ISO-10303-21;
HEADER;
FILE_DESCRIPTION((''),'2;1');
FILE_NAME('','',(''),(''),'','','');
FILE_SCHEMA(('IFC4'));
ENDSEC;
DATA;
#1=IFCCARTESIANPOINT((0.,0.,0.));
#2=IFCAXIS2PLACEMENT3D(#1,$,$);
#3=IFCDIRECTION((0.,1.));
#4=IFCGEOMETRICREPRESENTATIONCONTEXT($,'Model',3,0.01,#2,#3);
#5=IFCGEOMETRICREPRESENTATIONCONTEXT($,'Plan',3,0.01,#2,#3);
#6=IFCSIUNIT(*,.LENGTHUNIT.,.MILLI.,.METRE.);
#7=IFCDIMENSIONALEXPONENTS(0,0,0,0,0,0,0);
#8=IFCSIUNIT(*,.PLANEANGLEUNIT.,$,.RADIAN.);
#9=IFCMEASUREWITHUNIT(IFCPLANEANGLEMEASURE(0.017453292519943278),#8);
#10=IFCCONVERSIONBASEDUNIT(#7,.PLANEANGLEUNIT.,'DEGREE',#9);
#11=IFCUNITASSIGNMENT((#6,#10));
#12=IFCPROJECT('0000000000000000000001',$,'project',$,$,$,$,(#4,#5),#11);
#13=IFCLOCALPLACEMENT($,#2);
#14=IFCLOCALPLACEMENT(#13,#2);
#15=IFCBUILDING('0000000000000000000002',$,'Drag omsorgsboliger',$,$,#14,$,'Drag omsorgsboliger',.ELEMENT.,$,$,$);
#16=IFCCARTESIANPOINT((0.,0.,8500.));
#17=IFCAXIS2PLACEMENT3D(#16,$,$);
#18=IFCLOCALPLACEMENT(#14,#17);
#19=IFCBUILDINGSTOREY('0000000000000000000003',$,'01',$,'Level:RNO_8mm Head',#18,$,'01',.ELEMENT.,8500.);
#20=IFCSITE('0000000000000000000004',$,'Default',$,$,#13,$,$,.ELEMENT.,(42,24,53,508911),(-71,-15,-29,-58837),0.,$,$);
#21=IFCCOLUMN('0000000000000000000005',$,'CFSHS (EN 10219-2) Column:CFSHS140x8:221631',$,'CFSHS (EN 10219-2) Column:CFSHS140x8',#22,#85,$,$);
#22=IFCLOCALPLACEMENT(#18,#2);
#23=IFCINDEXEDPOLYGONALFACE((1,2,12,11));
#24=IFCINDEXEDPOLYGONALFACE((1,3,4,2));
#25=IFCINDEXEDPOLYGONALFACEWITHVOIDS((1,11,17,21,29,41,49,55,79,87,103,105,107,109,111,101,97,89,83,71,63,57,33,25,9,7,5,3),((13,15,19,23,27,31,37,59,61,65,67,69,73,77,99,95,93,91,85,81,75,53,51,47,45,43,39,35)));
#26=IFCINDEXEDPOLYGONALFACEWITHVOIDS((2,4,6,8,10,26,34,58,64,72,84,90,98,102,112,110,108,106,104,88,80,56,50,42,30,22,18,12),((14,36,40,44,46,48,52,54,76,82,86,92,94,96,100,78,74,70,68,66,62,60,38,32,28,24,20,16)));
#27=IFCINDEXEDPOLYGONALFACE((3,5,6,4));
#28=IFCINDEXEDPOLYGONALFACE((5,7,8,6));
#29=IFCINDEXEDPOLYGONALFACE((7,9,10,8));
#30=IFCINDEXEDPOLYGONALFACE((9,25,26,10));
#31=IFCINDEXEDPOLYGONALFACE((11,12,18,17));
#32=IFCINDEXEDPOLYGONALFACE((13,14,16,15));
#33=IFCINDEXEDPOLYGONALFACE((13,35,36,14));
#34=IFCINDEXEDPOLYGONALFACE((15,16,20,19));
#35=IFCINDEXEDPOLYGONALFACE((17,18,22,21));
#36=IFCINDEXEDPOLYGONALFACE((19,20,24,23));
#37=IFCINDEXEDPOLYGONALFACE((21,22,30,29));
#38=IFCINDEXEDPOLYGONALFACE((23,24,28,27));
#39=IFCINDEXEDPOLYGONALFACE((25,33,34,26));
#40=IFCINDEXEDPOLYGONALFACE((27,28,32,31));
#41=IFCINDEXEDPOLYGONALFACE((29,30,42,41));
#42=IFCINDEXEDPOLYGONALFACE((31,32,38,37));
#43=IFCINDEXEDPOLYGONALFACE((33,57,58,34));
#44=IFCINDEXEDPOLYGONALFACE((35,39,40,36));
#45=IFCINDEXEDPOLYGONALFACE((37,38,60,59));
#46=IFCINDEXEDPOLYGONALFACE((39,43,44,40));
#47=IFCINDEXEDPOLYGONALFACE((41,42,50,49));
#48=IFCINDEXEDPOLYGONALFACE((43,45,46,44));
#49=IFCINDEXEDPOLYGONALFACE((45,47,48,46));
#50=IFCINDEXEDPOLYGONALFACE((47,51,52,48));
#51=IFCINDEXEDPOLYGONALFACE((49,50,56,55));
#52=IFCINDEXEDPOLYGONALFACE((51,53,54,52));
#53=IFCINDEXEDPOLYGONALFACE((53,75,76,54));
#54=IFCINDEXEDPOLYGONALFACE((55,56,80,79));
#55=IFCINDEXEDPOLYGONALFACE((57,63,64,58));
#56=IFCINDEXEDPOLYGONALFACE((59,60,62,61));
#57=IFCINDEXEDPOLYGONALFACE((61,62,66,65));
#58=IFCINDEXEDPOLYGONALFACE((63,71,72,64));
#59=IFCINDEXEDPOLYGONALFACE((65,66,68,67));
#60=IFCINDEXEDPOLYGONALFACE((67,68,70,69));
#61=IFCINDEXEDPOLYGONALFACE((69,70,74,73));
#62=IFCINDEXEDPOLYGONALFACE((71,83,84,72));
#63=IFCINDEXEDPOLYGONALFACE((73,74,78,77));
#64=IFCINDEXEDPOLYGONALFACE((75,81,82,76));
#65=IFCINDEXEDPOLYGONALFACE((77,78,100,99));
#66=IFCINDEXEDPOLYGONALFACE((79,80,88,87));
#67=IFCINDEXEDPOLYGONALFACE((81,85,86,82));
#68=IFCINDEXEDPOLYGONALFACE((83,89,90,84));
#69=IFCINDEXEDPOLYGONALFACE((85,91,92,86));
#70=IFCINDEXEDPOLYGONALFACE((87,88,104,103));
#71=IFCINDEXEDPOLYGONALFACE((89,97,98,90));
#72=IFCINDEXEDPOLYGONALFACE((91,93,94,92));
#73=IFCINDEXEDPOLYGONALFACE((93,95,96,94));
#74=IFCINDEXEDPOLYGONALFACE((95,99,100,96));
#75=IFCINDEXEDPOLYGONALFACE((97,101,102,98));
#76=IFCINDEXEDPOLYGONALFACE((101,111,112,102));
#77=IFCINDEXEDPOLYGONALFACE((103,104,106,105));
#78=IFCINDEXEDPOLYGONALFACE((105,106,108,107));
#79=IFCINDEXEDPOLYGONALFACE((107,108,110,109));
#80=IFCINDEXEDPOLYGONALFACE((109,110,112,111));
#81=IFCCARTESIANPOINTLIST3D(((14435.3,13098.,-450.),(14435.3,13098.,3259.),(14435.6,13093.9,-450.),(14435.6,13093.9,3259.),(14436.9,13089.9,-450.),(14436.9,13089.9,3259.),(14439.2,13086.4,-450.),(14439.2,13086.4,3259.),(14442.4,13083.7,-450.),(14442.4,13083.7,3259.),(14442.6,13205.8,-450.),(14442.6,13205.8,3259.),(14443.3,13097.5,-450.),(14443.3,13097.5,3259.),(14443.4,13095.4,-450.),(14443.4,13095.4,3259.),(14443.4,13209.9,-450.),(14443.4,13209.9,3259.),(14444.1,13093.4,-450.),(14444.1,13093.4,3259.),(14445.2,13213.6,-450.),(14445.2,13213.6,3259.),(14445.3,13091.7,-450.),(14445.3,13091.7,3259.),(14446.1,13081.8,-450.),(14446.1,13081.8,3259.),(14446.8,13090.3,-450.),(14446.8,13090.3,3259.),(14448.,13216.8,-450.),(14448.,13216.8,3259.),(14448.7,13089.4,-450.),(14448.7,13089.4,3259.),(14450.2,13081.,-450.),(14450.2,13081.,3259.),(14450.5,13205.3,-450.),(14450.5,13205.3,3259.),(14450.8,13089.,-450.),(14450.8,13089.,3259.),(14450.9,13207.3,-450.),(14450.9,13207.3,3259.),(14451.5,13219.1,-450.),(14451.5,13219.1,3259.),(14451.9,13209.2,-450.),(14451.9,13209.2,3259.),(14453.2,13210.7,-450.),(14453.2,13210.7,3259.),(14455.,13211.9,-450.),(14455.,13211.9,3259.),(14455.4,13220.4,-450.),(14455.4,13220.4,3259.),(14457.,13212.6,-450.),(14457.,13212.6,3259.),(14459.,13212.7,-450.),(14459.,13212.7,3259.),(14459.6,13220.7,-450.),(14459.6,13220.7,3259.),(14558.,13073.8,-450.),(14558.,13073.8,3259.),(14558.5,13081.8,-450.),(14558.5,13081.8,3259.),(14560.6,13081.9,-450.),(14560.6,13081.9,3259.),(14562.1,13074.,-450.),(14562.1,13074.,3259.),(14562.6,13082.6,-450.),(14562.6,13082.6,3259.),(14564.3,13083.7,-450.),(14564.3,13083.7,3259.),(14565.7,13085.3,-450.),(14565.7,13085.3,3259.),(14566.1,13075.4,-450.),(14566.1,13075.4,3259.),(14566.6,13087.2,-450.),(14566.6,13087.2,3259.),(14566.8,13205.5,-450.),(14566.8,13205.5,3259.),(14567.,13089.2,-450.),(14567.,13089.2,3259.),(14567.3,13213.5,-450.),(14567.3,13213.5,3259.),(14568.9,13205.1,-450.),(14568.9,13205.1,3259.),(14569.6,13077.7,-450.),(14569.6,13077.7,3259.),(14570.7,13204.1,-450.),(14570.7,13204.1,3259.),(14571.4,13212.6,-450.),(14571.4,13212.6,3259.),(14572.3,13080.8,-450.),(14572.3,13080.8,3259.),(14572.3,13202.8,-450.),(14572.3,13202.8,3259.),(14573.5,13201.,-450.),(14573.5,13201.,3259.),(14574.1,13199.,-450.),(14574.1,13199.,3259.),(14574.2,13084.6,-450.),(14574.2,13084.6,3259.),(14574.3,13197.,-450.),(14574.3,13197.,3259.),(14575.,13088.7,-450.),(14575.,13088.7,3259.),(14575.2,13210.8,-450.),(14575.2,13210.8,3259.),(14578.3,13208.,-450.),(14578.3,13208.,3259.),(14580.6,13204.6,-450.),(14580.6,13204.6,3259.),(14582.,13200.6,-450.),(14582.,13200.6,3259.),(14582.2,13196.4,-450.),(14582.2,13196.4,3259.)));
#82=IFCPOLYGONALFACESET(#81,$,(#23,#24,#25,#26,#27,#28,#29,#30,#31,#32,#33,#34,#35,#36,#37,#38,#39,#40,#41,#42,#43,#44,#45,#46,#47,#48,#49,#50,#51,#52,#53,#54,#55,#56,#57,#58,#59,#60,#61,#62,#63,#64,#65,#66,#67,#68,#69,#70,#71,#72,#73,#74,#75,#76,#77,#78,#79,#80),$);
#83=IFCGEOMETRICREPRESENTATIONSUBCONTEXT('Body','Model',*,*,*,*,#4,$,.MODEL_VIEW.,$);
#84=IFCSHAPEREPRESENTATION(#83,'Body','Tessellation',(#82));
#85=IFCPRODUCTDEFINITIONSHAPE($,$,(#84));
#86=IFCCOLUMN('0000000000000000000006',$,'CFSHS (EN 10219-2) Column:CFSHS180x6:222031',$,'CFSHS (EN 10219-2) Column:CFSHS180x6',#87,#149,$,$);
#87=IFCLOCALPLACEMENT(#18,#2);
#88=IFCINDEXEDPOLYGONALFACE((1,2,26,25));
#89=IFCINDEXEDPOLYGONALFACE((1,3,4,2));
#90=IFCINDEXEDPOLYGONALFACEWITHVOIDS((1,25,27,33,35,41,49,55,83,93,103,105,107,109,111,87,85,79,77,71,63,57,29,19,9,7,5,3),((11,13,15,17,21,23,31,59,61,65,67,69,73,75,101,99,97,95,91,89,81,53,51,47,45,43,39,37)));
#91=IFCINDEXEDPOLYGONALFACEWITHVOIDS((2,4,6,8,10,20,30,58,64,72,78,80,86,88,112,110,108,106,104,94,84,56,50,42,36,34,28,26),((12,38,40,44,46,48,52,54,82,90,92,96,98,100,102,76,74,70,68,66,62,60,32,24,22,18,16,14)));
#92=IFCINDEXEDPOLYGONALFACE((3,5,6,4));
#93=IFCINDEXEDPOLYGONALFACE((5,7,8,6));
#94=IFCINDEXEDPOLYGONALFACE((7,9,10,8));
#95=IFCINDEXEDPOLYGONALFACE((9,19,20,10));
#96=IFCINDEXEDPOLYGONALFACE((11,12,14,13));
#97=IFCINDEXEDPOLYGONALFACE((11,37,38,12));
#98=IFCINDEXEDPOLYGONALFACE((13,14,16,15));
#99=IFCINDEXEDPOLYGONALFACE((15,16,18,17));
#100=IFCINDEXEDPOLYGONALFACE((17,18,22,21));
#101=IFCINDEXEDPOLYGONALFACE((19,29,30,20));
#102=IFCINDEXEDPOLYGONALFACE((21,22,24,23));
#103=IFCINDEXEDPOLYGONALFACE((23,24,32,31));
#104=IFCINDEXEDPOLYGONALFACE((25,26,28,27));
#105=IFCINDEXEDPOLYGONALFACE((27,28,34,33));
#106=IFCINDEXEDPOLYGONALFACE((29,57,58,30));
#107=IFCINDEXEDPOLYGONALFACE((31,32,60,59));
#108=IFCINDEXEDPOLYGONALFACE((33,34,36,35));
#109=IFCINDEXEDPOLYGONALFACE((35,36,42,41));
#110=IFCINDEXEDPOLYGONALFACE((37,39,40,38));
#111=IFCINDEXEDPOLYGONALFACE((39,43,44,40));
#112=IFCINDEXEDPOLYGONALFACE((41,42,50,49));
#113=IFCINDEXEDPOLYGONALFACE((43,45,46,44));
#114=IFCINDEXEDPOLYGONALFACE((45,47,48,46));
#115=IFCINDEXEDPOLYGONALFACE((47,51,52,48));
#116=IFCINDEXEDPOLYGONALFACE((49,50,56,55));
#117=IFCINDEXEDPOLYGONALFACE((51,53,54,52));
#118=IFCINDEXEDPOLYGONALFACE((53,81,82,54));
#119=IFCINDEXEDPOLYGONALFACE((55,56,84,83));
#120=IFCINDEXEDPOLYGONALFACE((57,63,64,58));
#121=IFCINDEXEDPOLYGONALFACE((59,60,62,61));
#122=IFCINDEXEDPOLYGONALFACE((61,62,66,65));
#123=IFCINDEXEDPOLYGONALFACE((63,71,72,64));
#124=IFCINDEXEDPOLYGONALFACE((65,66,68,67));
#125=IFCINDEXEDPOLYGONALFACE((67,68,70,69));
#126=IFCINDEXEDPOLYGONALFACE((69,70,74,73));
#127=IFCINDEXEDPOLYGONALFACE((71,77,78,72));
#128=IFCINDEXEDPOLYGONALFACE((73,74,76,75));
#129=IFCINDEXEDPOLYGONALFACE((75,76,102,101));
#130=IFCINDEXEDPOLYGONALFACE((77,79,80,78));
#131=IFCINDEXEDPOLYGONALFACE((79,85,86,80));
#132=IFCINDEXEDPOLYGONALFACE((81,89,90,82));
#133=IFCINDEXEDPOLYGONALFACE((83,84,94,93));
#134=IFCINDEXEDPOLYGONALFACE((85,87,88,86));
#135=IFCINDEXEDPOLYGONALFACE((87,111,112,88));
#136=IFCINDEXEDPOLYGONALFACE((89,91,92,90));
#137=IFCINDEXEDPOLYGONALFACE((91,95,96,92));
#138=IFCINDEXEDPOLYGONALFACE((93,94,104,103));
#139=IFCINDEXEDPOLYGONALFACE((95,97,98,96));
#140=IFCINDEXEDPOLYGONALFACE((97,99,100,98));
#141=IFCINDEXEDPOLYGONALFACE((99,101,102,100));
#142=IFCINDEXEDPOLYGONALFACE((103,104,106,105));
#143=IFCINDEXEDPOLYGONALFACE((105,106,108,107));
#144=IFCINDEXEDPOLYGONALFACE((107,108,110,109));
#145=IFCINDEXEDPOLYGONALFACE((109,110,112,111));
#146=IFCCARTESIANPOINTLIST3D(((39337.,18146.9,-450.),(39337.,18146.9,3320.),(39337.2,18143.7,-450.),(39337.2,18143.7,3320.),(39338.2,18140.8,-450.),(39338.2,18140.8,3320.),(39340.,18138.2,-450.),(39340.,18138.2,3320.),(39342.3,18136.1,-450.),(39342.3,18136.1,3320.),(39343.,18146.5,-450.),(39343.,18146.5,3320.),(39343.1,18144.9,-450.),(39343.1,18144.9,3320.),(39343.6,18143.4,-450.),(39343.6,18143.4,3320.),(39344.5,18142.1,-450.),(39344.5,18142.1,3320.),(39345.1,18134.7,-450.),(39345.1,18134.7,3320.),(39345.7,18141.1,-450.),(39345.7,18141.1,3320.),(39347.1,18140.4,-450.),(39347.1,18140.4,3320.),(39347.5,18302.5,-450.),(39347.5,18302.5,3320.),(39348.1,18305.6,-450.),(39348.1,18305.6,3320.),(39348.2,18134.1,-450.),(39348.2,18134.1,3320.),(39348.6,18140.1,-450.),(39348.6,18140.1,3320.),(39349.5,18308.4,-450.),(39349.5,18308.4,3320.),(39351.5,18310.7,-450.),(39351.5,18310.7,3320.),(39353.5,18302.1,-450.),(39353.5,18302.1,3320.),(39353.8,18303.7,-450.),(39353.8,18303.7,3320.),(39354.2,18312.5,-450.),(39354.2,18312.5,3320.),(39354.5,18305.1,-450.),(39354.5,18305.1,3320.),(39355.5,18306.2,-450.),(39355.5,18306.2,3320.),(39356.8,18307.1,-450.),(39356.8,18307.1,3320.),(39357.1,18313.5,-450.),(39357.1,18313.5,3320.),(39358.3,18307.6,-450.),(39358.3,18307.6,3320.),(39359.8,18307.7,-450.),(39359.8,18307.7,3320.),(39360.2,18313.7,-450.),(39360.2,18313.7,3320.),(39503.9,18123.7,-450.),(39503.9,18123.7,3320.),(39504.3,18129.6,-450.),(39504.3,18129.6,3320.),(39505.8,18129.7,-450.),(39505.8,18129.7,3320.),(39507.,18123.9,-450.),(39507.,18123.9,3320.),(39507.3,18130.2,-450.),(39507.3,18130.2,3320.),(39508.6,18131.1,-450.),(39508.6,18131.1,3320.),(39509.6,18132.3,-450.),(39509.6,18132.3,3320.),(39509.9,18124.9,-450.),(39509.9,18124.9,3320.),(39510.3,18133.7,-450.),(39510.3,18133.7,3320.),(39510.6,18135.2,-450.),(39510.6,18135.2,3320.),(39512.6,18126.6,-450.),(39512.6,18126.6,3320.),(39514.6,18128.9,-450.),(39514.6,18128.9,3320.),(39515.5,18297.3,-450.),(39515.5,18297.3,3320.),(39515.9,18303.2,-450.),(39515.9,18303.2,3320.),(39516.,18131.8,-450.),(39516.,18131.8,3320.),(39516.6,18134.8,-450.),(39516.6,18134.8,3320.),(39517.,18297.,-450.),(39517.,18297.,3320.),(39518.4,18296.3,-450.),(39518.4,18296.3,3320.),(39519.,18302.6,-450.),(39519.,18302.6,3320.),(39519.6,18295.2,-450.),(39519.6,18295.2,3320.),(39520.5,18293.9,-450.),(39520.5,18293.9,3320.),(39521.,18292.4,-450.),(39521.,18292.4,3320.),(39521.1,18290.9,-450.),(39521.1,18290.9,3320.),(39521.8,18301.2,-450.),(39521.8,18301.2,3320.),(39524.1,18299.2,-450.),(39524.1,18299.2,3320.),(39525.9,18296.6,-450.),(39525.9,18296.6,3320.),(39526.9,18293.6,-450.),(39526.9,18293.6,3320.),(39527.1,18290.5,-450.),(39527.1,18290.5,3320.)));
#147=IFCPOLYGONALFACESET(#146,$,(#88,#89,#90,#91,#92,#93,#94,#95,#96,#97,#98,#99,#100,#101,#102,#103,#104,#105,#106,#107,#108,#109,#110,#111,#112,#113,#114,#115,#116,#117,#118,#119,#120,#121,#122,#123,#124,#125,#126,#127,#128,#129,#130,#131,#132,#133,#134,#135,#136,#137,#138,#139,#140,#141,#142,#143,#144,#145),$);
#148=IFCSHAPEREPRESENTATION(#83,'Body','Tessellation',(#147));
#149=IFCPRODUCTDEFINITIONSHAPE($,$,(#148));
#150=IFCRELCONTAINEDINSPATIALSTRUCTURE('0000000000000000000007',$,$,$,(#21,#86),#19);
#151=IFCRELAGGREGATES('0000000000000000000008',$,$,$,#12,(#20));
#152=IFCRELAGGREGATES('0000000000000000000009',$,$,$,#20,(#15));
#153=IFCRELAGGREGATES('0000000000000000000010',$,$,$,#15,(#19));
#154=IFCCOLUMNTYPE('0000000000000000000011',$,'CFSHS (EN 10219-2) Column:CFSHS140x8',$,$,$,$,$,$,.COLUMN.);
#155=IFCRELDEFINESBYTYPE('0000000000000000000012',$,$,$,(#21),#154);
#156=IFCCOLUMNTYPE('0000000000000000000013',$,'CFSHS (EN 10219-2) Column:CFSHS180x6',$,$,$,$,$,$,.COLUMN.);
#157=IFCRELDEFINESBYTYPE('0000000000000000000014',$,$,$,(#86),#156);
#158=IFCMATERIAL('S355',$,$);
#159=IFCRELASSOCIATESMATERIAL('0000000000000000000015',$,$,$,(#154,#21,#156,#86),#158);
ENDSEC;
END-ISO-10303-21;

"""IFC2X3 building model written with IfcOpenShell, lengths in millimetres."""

from ifc_helpers import new_model, entity, si_unit, converted_unit, direction, frame, frame_2d, origin, place, context, subcontext, project, spatial, polyline, circle_curve, parameter, trimmed, segment, composite_curve, outline, extrude, source, transform, mapped, material, type_object, type_shapes, element, save


model = new_model("IFC2X3")

# Units and contexts
model_context = context("Model", 3, precision=0.01, world=origin(), true_north=direction((0.0, 1.0)))
plan_context = context("Plan", 3, precision=0.01, world=origin(), true_north=direction((0.0, 1.0)))
body_context = subcontext(model_context, "Body", "Model", "MODEL_VIEW")
ifc_project = project(units=[si_unit("LENGTHUNIT", "METRE", prefix="MILLI"), converted_unit("PLANEANGLEUNIT", "DEGREE", entity("IfcPlaneAngleMeasure", 0.017453292519943278), si_unit("PLANEANGLEUNIT", "RADIAN"), dimensions=[0, 0, 0, 0, 0, 0, 0])], contexts=[model_context, plan_context])

# Site, building, storey
site_placement = place(None, origin())
site = spatial("IfcSite", under=ifc_project, at=site_placement, Name="Default", CompositionType="ELEMENT", RefLatitude=(42, 24, 53, 508911), RefLongitude=(-71, -15, -29, -58837), RefElevation=0.0)
building_placement = place(site_placement, origin())
building = spatial("IfcBuilding", under=site, at=building_placement, Name="Drag omsorgsboliger", LongName="Drag omsorgsboliger", CompositionType="ELEMENT")
storey_placement = place(building_placement, frame((0.0, 0.0, 8500.0)))
storey = spatial("IfcBuildingStorey", under=building, at=storey_placement, Name="01", ObjectType="Level:RNO_8mm Head", LongName="01", CompositionType="ELEMENT", Elevation=8500.0)

# Columns
ifc_material = material(Name="S355")
column_type_1 = type_object("IfcColumnType", Name="CFSHS (EN 10219-2) Column:CFSHS140x8", PredefinedType="COLUMN", material=ifc_material)
shared_shape_1 = source(origin(), body_context, "Body", "SweptSolid", [
    extrude(outline(composite_curve([segment(polyline([(-54.0, -70.0), (54.0, -70.0)]), True, "CONTINUOUS"), segment(trimmed(circle_curve(frame_2d((54.0, -54.0), x_axis=(-1.0, 0.0)), 16.0), [parameter(90.0)], [parameter(180.0)], True, "PARAMETER"), True, "CONTINUOUS"), segment(polyline([(70.0, -54.0), (70.0, 54.0)]), True, "CONTINUOUS"), segment(trimmed(circle_curve(frame_2d((54.0, 54.0), x_axis=(-1.0, 0.0)), 16.0), [parameter(180.0)], [parameter(270.0)], True, "PARAMETER"), True, "CONTINUOUS"), segment(polyline([(54.0, 70.0), (-54.0, 70.0)]), True, "CONTINUOUS"), segment(trimmed(circle_curve(frame_2d((-54.0, 54.0), x_axis=(-1.0, 0.0)), 16.0), [parameter(270.0)], [parameter(360.0)], True, "PARAMETER"), True, "CONTINUOUS"), segment(polyline([(-70.0, 54.0), (-70.0, -54.0)]), True, "CONTINUOUS"), segment(trimmed(circle_curve(frame_2d((-54.0, -54.0), x_axis=(-1.0, 0.0)), 16.0), [parameter(360.0)], [parameter(90.0)], True, "PARAMETER"), True, "CONTINUOUS")], self_intersect=False), holes=[composite_curve([segment(trimmed(circle_curve(frame_2d((-54.0, -54.0), x_axis=(-1.0, 0.0)), 8.0), [parameter(360.0)], [parameter(90.0)], True, "PARAMETER"), False, "CONTINUOUS"), segment(polyline([(-62.0, -54.0), (-62.0, 54.0)]), True, "CONTINUOUS"), segment(trimmed(circle_curve(frame_2d((-54.0, 54.0), x_axis=(-1.0, 0.0)), 8.0), [parameter(270.0)], [parameter(360.0)], True, "PARAMETER"), False, "CONTINUOUS"), segment(polyline([(-54.0, 62.0), (54.0, 62.0)]), True, "CONTINUOUS"), segment(trimmed(circle_curve(frame_2d((54.0, 54.0), x_axis=(-1.0, 0.0)), 8.0), [parameter(180.0)], [parameter(270.0)], True, "PARAMETER"), False, "CONTINUOUS"), segment(polyline([(62.0, 54.0), (62.0, -54.0)]), True, "CONTINUOUS"), segment(trimmed(circle_curve(frame_2d((54.0, -54.0), x_axis=(-1.0, 0.0)), 8.0), [parameter(90.0)], [parameter(180.0)], True, "PARAMETER"), False, "CONTINUOUS"), segment(polyline([(54.0, -62.0), (-54.0, -62.0)]), True, "CONTINUOUS")], self_intersect=False)]), frame((14508.8, 13147.2, 8050.0), z_axis=(0.0, 0.0, 1.0), x_axis=(-0.997758, 0.066923, 0.0)), (0.0, 0.0, 1.0), 3709.0),
])
type_shapes(column_type_1, [shared_shape_1])
column_1_placement = place(storey_placement, frame((0.0, 0.0, -8500.0)))
element("IfcColumn", 1, at=column_1_placement, inside=storey, type_object=column_type_1, material=ifc_material, Name="CFSHS (EN 10219-2) Column:CFSHS140x8:221631", ObjectType="CFSHS (EN 10219-2) Column:CFSHS140x8", context=body_context, shape_type="MappedRepresentation", body=[
    mapped(shared_shape_1, transform((0.0, 0.0, 0.0), scale=1.0)),
])
column_type_2 = type_object("IfcColumnType", Name="CFSHS (EN 10219-2) Column:CFSHS180x6", PredefinedType="COLUMN", material=ifc_material)
shared_shape_2 = source(origin(), body_context, "Body", "SweptSolid", [
    extrude(outline(composite_curve([segment(polyline([(-78.0, -90.0), (78.0, -90.0)]), True, "CONTINUOUS"), segment(trimmed(circle_curve(frame_2d((78.0, -78.0), x_axis=(-1.0, 0.0)), 12.0), [parameter(90.0)], [parameter(180.0)], True, "PARAMETER"), True, "CONTINUOUS"), segment(polyline([(90.0, -78.0), (90.0, 78.0)]), True, "CONTINUOUS"), segment(trimmed(circle_curve(frame_2d((78.0, 78.0), x_axis=(-1.0, 0.0)), 12.0), [parameter(180.0)], [parameter(270.0)], True, "PARAMETER"), True, "CONTINUOUS"), segment(polyline([(78.0, 90.0), (-78.0, 90.0)]), True, "CONTINUOUS"), segment(trimmed(circle_curve(frame_2d((-78.0, 78.0), x_axis=(-1.0, 0.0)), 12.0), [parameter(270.0)], [parameter(360.0)], True, "PARAMETER"), True, "CONTINUOUS"), segment(polyline([(-90.0, 78.0), (-90.0, -78.0)]), True, "CONTINUOUS"), segment(trimmed(circle_curve(frame_2d((-78.0, -78.0), x_axis=(-1.0, 0.0)), 12.0), [parameter(360.0)], [parameter(90.0)], True, "PARAMETER"), True, "CONTINUOUS")], self_intersect=False), holes=[composite_curve([segment(trimmed(circle_curve(frame_2d((-78.0, -78.0), x_axis=(-1.0, 0.0)), 6.0), [parameter(360.0)], [parameter(90.0)], True, "PARAMETER"), False, "CONTINUOUS"), segment(polyline([(-84.0, -78.0), (-84.0, 78.0)]), True, "CONTINUOUS"), segment(trimmed(circle_curve(frame_2d((-78.0, 78.0), x_axis=(-1.0, 0.0)), 6.0), [parameter(270.0)], [parameter(360.0)], True, "PARAMETER"), False, "CONTINUOUS"), segment(polyline([(-78.0, 84.0), (78.0, 84.0)]), True, "CONTINUOUS"), segment(trimmed(circle_curve(frame_2d((78.0, 78.0), x_axis=(-1.0, 0.0)), 6.0), [parameter(180.0)], [parameter(270.0)], True, "PARAMETER"), False, "CONTINUOUS"), segment(polyline([(84.0, 78.0), (84.0, -78.0)]), True, "CONTINUOUS"), segment(trimmed(circle_curve(frame_2d((78.0, -78.0), x_axis=(-1.0, 0.0)), 6.0), [parameter(90.0)], [parameter(180.0)], True, "PARAMETER"), False, "CONTINUOUS"), segment(polyline([(78.0, -84.0), (-78.0, -84.0)]), True, "CONTINUOUS")], self_intersect=False)]), frame((39432.0, 18218.7, 8050.0), z_axis=(0.0, 0.0, 1.0), x_axis=(-0.997758, 0.066923, 0.0)), (0.0, 0.0, 1.0), 3770.0),
])
type_shapes(column_type_2, [shared_shape_2])
column_2_placement = place(storey_placement, frame((0.0, 0.0, -8500.0)))
element("IfcColumn", 2, at=column_2_placement, inside=storey, type_object=column_type_2, material=ifc_material, Name="CFSHS (EN 10219-2) Column:CFSHS180x6:222031", ObjectType="CFSHS (EN 10219-2) Column:CFSHS180x6", context=body_context, shape_type="MappedRepresentation", body=[
    mapped(shared_shape_2, transform((0.0, 0.0, 0.0), scale=1.0)),
])

save(model, "model.ifc")
